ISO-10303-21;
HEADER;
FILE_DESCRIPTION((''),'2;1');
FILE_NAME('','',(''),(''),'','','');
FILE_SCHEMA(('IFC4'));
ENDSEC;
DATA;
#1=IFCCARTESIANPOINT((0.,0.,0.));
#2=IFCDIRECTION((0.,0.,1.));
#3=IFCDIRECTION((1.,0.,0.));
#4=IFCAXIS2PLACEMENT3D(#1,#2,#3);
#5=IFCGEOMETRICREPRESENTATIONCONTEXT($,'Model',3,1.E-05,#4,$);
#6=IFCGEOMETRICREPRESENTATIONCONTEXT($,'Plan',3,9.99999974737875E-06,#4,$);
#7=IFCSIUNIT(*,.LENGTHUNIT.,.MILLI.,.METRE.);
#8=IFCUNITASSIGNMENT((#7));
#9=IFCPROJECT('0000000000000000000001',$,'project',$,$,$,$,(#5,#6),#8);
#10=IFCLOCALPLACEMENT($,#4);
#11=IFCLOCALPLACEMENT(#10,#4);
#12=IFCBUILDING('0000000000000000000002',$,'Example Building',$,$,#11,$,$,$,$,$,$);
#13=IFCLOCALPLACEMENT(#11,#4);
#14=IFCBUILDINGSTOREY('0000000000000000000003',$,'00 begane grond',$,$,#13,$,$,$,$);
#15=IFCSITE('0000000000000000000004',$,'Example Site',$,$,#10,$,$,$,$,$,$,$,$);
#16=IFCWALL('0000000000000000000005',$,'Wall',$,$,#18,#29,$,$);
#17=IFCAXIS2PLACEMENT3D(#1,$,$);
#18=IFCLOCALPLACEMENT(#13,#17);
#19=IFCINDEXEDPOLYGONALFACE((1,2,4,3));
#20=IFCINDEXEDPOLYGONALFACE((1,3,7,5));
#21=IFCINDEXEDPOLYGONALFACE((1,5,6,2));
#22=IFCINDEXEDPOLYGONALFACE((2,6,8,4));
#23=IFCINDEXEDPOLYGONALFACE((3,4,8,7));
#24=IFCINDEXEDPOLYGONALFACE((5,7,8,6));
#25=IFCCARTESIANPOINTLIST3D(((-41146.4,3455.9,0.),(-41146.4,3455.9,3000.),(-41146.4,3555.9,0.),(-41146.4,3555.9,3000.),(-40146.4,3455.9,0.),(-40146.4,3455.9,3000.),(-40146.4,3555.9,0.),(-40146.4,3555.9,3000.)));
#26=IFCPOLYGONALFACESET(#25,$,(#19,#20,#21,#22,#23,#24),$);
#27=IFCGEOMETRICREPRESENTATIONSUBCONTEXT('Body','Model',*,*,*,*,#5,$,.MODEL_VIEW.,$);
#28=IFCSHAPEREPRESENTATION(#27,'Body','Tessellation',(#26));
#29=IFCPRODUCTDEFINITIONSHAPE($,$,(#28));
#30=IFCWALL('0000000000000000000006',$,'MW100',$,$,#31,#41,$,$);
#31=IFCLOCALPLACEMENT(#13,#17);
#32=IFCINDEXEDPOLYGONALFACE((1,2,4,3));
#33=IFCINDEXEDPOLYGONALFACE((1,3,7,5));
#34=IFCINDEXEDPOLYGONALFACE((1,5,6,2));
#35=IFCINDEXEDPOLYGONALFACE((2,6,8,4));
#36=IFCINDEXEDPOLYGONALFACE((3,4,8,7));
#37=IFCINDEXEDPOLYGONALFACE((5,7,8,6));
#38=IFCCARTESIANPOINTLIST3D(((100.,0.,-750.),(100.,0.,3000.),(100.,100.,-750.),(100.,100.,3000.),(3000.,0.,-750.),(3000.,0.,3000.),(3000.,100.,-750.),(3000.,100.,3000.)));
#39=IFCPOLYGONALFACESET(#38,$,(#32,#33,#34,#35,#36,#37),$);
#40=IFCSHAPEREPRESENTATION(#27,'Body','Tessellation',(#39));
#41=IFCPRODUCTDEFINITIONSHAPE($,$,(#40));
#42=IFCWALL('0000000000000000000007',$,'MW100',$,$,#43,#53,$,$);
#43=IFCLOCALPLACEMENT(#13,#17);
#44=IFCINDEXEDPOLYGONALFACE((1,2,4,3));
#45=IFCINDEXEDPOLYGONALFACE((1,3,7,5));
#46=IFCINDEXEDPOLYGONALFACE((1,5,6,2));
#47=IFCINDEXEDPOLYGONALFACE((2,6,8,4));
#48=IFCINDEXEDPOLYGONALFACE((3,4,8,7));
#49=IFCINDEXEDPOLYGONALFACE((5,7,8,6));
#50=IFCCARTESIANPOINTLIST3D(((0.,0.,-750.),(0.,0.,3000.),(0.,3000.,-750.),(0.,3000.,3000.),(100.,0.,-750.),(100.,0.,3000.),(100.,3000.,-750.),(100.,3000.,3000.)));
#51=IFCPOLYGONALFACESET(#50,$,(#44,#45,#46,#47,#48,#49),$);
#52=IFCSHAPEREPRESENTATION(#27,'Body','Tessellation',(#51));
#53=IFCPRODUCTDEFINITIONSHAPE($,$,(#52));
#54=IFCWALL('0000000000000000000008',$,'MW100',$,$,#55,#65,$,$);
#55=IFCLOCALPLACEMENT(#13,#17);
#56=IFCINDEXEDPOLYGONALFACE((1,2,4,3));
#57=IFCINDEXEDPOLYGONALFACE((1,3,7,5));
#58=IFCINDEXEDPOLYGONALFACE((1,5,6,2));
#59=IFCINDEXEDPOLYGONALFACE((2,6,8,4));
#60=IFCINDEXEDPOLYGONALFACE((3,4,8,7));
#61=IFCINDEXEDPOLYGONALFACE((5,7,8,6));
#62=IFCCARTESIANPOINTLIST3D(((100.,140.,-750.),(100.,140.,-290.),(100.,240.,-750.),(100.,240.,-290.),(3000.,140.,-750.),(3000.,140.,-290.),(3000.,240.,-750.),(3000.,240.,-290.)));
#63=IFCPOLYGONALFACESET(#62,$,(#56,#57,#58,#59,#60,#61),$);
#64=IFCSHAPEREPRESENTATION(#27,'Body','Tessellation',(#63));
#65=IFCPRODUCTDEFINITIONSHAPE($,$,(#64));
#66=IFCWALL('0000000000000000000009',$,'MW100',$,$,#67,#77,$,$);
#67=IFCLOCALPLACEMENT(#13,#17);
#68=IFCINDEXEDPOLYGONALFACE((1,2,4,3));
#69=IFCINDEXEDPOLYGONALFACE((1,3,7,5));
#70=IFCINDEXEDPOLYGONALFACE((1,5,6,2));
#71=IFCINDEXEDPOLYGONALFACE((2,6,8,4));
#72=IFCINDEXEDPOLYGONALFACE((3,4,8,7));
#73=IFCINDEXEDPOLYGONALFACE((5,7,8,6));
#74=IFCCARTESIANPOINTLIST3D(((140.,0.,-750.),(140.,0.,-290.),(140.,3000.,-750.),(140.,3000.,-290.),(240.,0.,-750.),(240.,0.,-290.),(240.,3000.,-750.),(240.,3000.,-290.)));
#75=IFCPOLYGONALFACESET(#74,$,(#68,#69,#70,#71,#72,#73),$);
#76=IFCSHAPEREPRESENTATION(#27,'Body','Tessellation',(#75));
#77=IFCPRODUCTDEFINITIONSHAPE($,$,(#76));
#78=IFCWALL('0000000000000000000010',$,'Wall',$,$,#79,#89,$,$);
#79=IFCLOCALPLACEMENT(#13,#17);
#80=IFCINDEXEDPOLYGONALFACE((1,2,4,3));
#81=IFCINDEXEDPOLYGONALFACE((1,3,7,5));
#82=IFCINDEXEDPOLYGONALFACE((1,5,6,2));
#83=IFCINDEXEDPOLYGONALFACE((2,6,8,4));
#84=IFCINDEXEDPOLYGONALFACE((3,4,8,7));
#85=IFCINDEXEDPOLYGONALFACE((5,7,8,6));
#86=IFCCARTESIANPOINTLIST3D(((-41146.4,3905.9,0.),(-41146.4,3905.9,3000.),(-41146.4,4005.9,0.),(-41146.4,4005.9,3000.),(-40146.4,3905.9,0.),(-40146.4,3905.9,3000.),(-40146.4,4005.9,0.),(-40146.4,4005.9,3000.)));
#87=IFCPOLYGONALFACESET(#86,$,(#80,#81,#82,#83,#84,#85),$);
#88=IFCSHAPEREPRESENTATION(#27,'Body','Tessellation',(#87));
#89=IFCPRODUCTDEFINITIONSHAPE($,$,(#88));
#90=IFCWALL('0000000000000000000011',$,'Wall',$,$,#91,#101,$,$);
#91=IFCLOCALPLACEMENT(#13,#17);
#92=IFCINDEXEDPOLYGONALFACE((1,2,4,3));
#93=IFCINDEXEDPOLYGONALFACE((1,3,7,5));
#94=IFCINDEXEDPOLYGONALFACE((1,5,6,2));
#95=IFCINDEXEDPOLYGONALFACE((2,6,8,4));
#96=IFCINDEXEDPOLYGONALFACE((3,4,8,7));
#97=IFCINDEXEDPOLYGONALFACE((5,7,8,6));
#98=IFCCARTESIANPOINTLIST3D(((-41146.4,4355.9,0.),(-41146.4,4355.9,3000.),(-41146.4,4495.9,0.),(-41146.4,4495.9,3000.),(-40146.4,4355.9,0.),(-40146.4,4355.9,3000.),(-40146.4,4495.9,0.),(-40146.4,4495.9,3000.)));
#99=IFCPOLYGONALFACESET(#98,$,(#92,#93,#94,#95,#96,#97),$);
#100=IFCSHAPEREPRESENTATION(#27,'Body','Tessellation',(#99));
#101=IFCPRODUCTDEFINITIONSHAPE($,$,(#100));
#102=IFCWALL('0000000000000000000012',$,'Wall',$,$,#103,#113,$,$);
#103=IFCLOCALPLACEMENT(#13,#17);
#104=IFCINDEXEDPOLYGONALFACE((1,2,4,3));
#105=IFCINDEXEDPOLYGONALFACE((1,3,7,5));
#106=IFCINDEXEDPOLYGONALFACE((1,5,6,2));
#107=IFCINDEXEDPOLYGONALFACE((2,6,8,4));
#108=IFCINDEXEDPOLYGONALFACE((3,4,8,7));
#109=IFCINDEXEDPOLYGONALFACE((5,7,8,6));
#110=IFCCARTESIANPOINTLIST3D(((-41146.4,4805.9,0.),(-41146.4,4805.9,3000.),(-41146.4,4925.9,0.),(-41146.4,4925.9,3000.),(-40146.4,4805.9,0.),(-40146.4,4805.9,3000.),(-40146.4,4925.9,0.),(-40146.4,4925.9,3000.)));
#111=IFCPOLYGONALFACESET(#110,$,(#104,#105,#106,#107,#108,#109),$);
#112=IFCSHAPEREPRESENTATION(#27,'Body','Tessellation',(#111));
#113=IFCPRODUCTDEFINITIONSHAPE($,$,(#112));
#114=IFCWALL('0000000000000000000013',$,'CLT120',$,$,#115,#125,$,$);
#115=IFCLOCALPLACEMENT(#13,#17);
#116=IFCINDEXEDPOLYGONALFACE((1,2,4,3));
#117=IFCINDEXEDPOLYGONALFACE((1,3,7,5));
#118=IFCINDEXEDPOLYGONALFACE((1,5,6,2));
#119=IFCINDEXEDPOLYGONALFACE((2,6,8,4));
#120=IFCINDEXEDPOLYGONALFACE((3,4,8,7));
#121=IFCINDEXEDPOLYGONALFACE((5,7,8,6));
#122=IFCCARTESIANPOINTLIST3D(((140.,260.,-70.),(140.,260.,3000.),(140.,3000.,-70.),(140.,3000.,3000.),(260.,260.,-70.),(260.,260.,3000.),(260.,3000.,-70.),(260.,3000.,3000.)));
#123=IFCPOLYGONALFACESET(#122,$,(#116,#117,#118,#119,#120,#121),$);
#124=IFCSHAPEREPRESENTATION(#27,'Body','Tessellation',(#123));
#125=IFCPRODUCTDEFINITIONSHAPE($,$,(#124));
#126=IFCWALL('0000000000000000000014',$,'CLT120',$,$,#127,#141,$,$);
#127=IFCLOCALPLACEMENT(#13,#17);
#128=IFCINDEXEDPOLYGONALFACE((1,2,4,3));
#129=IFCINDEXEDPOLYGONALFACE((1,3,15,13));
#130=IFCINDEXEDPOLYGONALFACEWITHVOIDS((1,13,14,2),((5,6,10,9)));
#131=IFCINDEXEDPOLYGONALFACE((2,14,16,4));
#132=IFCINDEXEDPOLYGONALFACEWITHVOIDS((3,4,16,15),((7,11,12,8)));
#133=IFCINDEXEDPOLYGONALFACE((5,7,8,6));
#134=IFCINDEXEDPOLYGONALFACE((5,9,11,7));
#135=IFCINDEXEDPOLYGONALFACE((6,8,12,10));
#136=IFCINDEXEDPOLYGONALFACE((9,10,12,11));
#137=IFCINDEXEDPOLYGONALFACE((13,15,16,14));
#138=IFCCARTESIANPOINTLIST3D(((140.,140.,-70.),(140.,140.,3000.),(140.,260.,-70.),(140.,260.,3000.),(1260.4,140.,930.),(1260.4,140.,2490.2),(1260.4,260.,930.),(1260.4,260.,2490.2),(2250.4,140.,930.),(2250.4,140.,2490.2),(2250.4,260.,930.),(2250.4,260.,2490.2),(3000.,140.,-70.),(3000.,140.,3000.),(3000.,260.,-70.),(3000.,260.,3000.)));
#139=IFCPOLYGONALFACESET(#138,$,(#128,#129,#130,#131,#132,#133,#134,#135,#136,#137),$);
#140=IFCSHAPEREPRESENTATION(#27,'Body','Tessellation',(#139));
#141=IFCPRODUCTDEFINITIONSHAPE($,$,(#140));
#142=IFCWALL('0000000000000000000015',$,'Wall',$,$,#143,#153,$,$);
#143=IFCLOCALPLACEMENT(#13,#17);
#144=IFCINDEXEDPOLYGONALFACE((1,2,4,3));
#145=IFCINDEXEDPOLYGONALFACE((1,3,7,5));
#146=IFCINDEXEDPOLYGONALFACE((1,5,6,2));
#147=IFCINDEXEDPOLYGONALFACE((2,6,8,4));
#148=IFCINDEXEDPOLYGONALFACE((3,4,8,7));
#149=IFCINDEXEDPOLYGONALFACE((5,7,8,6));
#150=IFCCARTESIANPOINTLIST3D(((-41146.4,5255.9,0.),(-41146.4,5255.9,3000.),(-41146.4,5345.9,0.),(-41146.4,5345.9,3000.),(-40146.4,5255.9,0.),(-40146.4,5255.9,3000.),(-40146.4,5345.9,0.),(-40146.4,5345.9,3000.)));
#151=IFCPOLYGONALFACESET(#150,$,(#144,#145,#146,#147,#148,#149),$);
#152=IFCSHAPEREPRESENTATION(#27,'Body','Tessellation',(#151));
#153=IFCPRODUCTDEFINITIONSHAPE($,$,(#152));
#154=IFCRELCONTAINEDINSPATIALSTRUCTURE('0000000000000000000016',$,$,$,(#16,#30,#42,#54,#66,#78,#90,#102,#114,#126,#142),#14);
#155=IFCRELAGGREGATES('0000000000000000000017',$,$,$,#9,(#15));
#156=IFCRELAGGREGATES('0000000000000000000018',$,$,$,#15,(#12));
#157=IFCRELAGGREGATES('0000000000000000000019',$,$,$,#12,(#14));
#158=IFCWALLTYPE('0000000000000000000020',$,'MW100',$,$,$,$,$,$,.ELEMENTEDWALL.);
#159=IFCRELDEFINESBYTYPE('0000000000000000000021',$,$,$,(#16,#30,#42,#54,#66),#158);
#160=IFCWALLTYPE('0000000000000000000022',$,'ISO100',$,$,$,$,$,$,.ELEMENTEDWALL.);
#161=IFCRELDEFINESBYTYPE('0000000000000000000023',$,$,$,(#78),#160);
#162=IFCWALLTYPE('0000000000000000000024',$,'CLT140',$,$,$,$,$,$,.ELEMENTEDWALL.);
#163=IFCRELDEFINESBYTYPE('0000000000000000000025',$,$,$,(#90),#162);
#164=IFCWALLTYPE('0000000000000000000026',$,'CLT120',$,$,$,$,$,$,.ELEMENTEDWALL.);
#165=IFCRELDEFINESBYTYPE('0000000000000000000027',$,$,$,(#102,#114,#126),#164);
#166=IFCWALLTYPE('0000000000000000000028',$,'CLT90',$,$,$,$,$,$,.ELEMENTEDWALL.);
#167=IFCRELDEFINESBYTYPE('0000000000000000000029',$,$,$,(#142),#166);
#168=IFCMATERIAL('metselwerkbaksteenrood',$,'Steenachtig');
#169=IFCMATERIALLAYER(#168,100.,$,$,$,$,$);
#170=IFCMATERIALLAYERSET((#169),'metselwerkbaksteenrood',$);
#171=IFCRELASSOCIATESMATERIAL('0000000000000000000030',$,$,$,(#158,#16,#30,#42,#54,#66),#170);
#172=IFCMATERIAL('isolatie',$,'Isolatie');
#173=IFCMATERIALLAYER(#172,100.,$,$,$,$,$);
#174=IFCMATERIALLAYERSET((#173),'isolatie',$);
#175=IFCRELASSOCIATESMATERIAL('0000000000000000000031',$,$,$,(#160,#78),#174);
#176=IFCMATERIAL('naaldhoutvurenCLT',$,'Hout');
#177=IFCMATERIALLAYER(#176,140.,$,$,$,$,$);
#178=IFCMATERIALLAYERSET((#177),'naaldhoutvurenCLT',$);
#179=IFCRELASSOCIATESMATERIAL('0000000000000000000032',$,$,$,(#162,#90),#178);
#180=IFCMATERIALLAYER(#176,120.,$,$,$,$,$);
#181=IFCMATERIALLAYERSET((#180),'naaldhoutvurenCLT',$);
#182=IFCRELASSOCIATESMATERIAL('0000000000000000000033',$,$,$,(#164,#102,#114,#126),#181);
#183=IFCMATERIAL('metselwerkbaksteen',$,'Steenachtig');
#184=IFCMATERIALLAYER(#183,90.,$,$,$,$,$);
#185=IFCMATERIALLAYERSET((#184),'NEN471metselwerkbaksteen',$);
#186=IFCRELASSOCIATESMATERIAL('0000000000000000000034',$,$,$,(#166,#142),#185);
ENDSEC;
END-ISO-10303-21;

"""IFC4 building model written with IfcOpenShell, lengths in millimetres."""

from ifc_helpers import new_model, si_unit, frame, origin_with_axes, place, context, subcontext, project, spatial, line, indexed_curve, outline, extrude, source, transform, mapped, material, layer, layer_set, layer_usage, type_object, element, save


model = new_model("IFC4")

# Units and contexts
model_context = context("Model", 3, precision=1e-05, world=origin_with_axes())
plan_context = context("Plan", 3, precision=9.99999974737875e-06, world=origin_with_axes())
body_context = subcontext(model_context, "Body", "Model", "MODEL_VIEW")
ifc_project = project(units=[si_unit("LENGTHUNIT", "METRE", prefix="MILLI")], contexts=[model_context, plan_context])

# Site, building, storey
site_placement = place(None, frame((0.0, 0.0, 0.0), z_axis=(0.0, 0.0, 1.0), x_axis=(1.0, 0.0, 0.0)))
site = spatial("IfcSite", under=ifc_project, at=site_placement, Name="Example Site")
building_placement = place(site_placement, origin_with_axes())
building = spatial("IfcBuilding", under=site, at=building_placement, Name="Example Building")
storey_placement = place(building_placement, origin_with_axes())
storey = spatial("IfcBuildingStorey", under=building, at=storey_placement, Name="00 begane grond")

# Shared definitions
ifc_material_1 = material(Name="isolatie", Category="Isolatie")
ifc_material_2 = material(Name="naaldhoutvurenCLT", Category="Hout")

# Walls
ifc_material_3 = material(Name="metselwerkbaksteenrood", Category="Steenachtig")
ifc_layer_1 = layer(ifc_material_3, 100.0)
ifc_layer_set_1 = layer_set([ifc_layer_1], Name="metselwerkbaksteenrood")
ifc_layer_usage_1 = layer_usage(ifc_layer_set_1, "AXIS2", "POSITIVE", 0.0)
wall_type_1 = type_object("IfcWallType", Name="MW100", PredefinedType="ELEMENTEDWALL", material=ifc_layer_set_1)
wall_1_placement = place(storey_placement, frame((-41146.4, 3455.9, 0.0), z_axis=(0.0, 0.0, 1.0), x_axis=(1.0, 0.0, 0.0)))
element("IfcWall", 1, at=wall_1_placement, inside=storey, type_object=wall_type_1, material=ifc_layer_usage_1, Name="Wall", context=body_context, shape_type="SweptSolid", body=[
    extrude(outline(indexed_curve([(0.0, 0.0), (0.0, 100.0), (1000.0, 100.0), (1000.0, 0.0), (0.0, 0.0)], self_intersect=False)), origin_with_axes(), (0.0, 0.0, 1.0), 3000.0),
])
ifc_layer_usage_2 = layer_usage(ifc_layer_set_1, "AXIS2", "POSITIVE", 0.0)
wall_2_placement = place(storey_placement, frame((100.0, 0.0, -750.0), z_axis=(0.0, 0.0, 1.0), x_axis=(1.0, 0.0, 0.0)))
element("IfcWall", 2, at=wall_2_placement, inside=storey, type_object=wall_type_1, material=ifc_layer_usage_2, Name="MW100", context=body_context, shape_type="SweptSolid", body=[
    extrude(outline(indexed_curve([(0.0, 0.0), (0.0, 100.0), (2900.0, 100.0), (2900.0, 0.0), (0.0, 0.0)], self_intersect=False)), origin_with_axes(), (0.0, 0.0, 1.0), 3750.0),
])
ifc_layer_usage_3 = layer_usage(ifc_layer_set_1, "AXIS2", "POSITIVE", 0.0)
wall_3_placement = place(storey_placement, frame((100.0, 0.0, -750.0), z_axis=(0.0, 0.0, 1.0), x_axis=(0.0, 1.0, 0.0)))
element("IfcWall", 3, at=wall_3_placement, inside=storey, type_object=wall_type_1, material=ifc_layer_usage_3, Name="MW100", context=body_context, shape_type="SweptSolid", body=[
    extrude(outline(indexed_curve([(0.0, 0.0), (0.0, 100.0), (3000.0, 100.0), (3000.0, 0.0), (0.0, 0.0)], self_intersect=False)), origin_with_axes(), (0.0, 0.0, 1.0), 3750.0),
])
ifc_layer_usage_4 = layer_usage(ifc_layer_set_1, "AXIS2", "POSITIVE", 0.0)
wall_4_placement = place(storey_placement, frame((100.0, 140.0, -750.0), z_axis=(0.0, 0.0, 1.0), x_axis=(1.0, 0.0, 0.0)))
element("IfcWall", 4, at=wall_4_placement, inside=storey, type_object=wall_type_1, material=ifc_layer_usage_4, Name="MW100", context=body_context, shape_type="SweptSolid", body=[
    extrude(outline(indexed_curve([(0.0, 0.0), (0.0, 100.0), (2900.0, 100.0), (2900.0, 0.0), (0.0, 0.0)], self_intersect=False)), origin_with_axes(), (0.0, 0.0, 1.0), 460.0),
])
ifc_layer_usage_5 = layer_usage(ifc_layer_set_1, "AXIS2", "POSITIVE", 0.0)
wall_5_placement = place(storey_placement, frame((240.0, 0.0, -750.0), z_axis=(0.0, 0.0, 1.0), x_axis=(0.0, 1.0, 0.0)))
element("IfcWall", 5, at=wall_5_placement, inside=storey, type_object=wall_type_1, material=ifc_layer_usage_5, Name="MW100", context=body_context, shape_type="SweptSolid", body=[
    extrude(outline(indexed_curve([(0.0, 0.0), (0.0, 100.0), (3000.0, 100.0), (3000.0, 0.0), (0.0, 0.0)], self_intersect=False)), origin_with_axes(), (0.0, 0.0, 1.0), 460.0),
])
ifc_layer_2 = layer(ifc_material_1, 100.0)
ifc_layer_set_2 = layer_set([ifc_layer_2], Name="isolatie")
ifc_layer_usage_6 = layer_usage(ifc_layer_set_2, "AXIS2", "POSITIVE", 0.0)
wall_type_2 = type_object("IfcWallType", Name="ISO100", PredefinedType="ELEMENTEDWALL", material=ifc_layer_set_2)
wall_6_placement = place(storey_placement, frame((-41146.4, 3905.9, 0.0), z_axis=(0.0, 0.0, 1.0), x_axis=(1.0, 0.0, 0.0)))
element("IfcWall", 6, at=wall_6_placement, inside=storey, type_object=wall_type_2, material=ifc_layer_usage_6, Name="Wall", context=body_context, shape_type="SweptSolid", body=[
    extrude(outline(indexed_curve([(0.0, 0.0), (0.0, 100.0), (1000.0, 100.0), (1000.0, 0.0), (0.0, 0.0)], self_intersect=False)), origin_with_axes(), (0.0, 0.0, 1.0), 3000.0),
])
ifc_layer_3 = layer(ifc_material_2, 140.0)
ifc_layer_set_3 = layer_set([ifc_layer_3], Name="naaldhoutvurenCLT")
ifc_layer_usage_7 = layer_usage(ifc_layer_set_3, "AXIS2", "POSITIVE", 0.0)
wall_type_3 = type_object("IfcWallType", Name="CLT140", PredefinedType="ELEMENTEDWALL", material=ifc_layer_set_3)
wall_7_placement = place(storey_placement, frame((-41146.4, 4355.9, 0.0), z_axis=(0.0, 0.0, 1.0), x_axis=(1.0, 0.0, 0.0)))
element("IfcWall", 7, at=wall_7_placement, inside=storey, type_object=wall_type_3, material=ifc_layer_usage_7, Name="Wall", context=body_context, shape_type="SweptSolid", body=[
    extrude(outline(indexed_curve([(0.0, 0.0), (0.0, 140.0), (1000.0, 140.0), (1000.0, 0.0), (0.0, 0.0)], self_intersect=False)), origin_with_axes(), (0.0, 0.0, 1.0), 3000.0),
])
ifc_layer_4 = layer(ifc_material_2, 120.0)
ifc_layer_set_4 = layer_set([ifc_layer_4], Name="naaldhoutvurenCLT")
ifc_layer_usage_8 = layer_usage(ifc_layer_set_4, "AXIS2", "POSITIVE", 0.0)
wall_type_4 = type_object("IfcWallType", Name="CLT120", PredefinedType="ELEMENTEDWALL", material=ifc_layer_set_4)
wall_8_placement = place(storey_placement, frame((-41146.4, 4805.9, 0.0), z_axis=(0.0, 0.0, 1.0), x_axis=(1.0, 0.0, 0.0)))
element("IfcWall", 8, at=wall_8_placement, inside=storey, type_object=wall_type_4, material=ifc_layer_usage_8, Name="Wall", context=body_context, shape_type="SweptSolid", body=[
    extrude(outline(indexed_curve([(0.0, 0.0), (0.0, 120.0), (1000.0, 120.0), (1000.0, 0.0), (0.0, 0.0)], self_intersect=False)), origin_with_axes(), (0.0, 0.0, 1.0), 3000.0),
])
ifc_layer_usage_9 = layer_usage(ifc_layer_set_4, "AXIS2", "POSITIVE", 0.0)
wall_9_placement = place(storey_placement, frame((260.0, 260.0, -70.0), z_axis=(0.0, 0.0, 1.0), x_axis=(0.0, 1.0, 0.0)))
element("IfcWall", 9, at=wall_9_placement, inside=storey, type_object=wall_type_4, material=ifc_layer_usage_9, Name="CLT120", context=body_context, shape_type="SweptSolid", body=[
    extrude(outline(indexed_curve([(0.0, 0.0), (0.0, 120.0), (2740.0, 120.0), (2740.0, 0.0), (0.0, 0.0)], self_intersect=False)), origin_with_axes(), (0.0, 0.0, 1.0), 3070.0),
])

# Wall, opening
ifc_layer_usage_10 = layer_usage(ifc_layer_set_4, "AXIS2", "POSITIVE", 0.0)
wall_10_placement = place(storey_placement, frame((140.0, 140.0, -70.0), z_axis=(0.0, 0.0, 1.0), x_axis=(1.0, 0.0, 0.0)))
wall_10 = element("IfcWall", 10, at=wall_10_placement, inside=storey, type_object=wall_type_4, material=ifc_layer_usage_10, Name="CLT120", context=body_context, shape_type="SweptSolid", body=[
    extrude(outline(indexed_curve([(0.0, 0.0), (0.0, 120.0), (2860.0, 120.0), (2860.0, 0.0), (0.0, 0.0)], self_intersect=False)), origin_with_axes(), (0.0, 0.0, 1.0), 3070.0),
])
shared_shape_1 = source(origin_with_axes(), body_context, "Body", "SweptSolid", [
    extrude(outline(indexed_curve([(0.0, 0.0), (990.0, 0.0), (990.0, 1560.2), (0.0, 1560.2)], segments=[line(1, 2, 3, 4, 1)])), frame((0.0, -600.0, 0.0), z_axis=(0.0, -1.0, 0.0), x_axis=(1.0, 0.0, 0.0)), (0.0, 0.0, -1.0), 1200.0),
])
opening_1_placement = place(wall_10_placement, frame((1120.4, -70.0, 1000.0), z_axis=(0.0, 0.0, 1.0), x_axis=(1.0, 0.0, 0.0)))
element("IfcOpeningElement", 11, at=opening_1_placement, cuts=wall_10, PredefinedType="OPENING", context=body_context, shape_type="MappedRepresentation", body=[
    mapped(shared_shape_1, transform((0.0, 0.0, 0.0), x_axis=(1.0, 0.0, 0.0), y_axis=(0.0, 1.0, 0.0), z_axis=(0.0, 0.0, 1.0), scale=1.0)),
])

# Wall
ifc_material_4 = material(Name="metselwerkbaksteen", Category="Steenachtig")
ifc_layer_5 = layer(ifc_material_4, 90.0)
ifc_layer_set_5 = layer_set([ifc_layer_5], Name="NEN471metselwerkbaksteen")
ifc_layer_usage_11 = layer_usage(ifc_layer_set_5, "AXIS2", "POSITIVE", 0.0)
wall_type_5 = type_object("IfcWallType", Name="CLT90", PredefinedType="ELEMENTEDWALL", material=ifc_layer_set_5)
wall_11_placement = place(storey_placement, frame((-41146.4, 5255.9, 0.0), z_axis=(0.0, 0.0, 1.0), x_axis=(1.0, 0.0, 0.0)))
element("IfcWall", 12, at=wall_11_placement, inside=storey, type_object=wall_type_5, material=ifc_layer_usage_11, Name="Wall", context=body_context, shape_type="SweptSolid", body=[
    extrude(outline(indexed_curve([(0.0, 0.0), (0.0, 90.0), (1000.0, 90.0), (1000.0, 0.0), (0.0, 0.0)], self_intersect=False)), origin_with_axes(), (0.0, 0.0, 1.0), 3000.0),
])

save(model, "model.ifc")
